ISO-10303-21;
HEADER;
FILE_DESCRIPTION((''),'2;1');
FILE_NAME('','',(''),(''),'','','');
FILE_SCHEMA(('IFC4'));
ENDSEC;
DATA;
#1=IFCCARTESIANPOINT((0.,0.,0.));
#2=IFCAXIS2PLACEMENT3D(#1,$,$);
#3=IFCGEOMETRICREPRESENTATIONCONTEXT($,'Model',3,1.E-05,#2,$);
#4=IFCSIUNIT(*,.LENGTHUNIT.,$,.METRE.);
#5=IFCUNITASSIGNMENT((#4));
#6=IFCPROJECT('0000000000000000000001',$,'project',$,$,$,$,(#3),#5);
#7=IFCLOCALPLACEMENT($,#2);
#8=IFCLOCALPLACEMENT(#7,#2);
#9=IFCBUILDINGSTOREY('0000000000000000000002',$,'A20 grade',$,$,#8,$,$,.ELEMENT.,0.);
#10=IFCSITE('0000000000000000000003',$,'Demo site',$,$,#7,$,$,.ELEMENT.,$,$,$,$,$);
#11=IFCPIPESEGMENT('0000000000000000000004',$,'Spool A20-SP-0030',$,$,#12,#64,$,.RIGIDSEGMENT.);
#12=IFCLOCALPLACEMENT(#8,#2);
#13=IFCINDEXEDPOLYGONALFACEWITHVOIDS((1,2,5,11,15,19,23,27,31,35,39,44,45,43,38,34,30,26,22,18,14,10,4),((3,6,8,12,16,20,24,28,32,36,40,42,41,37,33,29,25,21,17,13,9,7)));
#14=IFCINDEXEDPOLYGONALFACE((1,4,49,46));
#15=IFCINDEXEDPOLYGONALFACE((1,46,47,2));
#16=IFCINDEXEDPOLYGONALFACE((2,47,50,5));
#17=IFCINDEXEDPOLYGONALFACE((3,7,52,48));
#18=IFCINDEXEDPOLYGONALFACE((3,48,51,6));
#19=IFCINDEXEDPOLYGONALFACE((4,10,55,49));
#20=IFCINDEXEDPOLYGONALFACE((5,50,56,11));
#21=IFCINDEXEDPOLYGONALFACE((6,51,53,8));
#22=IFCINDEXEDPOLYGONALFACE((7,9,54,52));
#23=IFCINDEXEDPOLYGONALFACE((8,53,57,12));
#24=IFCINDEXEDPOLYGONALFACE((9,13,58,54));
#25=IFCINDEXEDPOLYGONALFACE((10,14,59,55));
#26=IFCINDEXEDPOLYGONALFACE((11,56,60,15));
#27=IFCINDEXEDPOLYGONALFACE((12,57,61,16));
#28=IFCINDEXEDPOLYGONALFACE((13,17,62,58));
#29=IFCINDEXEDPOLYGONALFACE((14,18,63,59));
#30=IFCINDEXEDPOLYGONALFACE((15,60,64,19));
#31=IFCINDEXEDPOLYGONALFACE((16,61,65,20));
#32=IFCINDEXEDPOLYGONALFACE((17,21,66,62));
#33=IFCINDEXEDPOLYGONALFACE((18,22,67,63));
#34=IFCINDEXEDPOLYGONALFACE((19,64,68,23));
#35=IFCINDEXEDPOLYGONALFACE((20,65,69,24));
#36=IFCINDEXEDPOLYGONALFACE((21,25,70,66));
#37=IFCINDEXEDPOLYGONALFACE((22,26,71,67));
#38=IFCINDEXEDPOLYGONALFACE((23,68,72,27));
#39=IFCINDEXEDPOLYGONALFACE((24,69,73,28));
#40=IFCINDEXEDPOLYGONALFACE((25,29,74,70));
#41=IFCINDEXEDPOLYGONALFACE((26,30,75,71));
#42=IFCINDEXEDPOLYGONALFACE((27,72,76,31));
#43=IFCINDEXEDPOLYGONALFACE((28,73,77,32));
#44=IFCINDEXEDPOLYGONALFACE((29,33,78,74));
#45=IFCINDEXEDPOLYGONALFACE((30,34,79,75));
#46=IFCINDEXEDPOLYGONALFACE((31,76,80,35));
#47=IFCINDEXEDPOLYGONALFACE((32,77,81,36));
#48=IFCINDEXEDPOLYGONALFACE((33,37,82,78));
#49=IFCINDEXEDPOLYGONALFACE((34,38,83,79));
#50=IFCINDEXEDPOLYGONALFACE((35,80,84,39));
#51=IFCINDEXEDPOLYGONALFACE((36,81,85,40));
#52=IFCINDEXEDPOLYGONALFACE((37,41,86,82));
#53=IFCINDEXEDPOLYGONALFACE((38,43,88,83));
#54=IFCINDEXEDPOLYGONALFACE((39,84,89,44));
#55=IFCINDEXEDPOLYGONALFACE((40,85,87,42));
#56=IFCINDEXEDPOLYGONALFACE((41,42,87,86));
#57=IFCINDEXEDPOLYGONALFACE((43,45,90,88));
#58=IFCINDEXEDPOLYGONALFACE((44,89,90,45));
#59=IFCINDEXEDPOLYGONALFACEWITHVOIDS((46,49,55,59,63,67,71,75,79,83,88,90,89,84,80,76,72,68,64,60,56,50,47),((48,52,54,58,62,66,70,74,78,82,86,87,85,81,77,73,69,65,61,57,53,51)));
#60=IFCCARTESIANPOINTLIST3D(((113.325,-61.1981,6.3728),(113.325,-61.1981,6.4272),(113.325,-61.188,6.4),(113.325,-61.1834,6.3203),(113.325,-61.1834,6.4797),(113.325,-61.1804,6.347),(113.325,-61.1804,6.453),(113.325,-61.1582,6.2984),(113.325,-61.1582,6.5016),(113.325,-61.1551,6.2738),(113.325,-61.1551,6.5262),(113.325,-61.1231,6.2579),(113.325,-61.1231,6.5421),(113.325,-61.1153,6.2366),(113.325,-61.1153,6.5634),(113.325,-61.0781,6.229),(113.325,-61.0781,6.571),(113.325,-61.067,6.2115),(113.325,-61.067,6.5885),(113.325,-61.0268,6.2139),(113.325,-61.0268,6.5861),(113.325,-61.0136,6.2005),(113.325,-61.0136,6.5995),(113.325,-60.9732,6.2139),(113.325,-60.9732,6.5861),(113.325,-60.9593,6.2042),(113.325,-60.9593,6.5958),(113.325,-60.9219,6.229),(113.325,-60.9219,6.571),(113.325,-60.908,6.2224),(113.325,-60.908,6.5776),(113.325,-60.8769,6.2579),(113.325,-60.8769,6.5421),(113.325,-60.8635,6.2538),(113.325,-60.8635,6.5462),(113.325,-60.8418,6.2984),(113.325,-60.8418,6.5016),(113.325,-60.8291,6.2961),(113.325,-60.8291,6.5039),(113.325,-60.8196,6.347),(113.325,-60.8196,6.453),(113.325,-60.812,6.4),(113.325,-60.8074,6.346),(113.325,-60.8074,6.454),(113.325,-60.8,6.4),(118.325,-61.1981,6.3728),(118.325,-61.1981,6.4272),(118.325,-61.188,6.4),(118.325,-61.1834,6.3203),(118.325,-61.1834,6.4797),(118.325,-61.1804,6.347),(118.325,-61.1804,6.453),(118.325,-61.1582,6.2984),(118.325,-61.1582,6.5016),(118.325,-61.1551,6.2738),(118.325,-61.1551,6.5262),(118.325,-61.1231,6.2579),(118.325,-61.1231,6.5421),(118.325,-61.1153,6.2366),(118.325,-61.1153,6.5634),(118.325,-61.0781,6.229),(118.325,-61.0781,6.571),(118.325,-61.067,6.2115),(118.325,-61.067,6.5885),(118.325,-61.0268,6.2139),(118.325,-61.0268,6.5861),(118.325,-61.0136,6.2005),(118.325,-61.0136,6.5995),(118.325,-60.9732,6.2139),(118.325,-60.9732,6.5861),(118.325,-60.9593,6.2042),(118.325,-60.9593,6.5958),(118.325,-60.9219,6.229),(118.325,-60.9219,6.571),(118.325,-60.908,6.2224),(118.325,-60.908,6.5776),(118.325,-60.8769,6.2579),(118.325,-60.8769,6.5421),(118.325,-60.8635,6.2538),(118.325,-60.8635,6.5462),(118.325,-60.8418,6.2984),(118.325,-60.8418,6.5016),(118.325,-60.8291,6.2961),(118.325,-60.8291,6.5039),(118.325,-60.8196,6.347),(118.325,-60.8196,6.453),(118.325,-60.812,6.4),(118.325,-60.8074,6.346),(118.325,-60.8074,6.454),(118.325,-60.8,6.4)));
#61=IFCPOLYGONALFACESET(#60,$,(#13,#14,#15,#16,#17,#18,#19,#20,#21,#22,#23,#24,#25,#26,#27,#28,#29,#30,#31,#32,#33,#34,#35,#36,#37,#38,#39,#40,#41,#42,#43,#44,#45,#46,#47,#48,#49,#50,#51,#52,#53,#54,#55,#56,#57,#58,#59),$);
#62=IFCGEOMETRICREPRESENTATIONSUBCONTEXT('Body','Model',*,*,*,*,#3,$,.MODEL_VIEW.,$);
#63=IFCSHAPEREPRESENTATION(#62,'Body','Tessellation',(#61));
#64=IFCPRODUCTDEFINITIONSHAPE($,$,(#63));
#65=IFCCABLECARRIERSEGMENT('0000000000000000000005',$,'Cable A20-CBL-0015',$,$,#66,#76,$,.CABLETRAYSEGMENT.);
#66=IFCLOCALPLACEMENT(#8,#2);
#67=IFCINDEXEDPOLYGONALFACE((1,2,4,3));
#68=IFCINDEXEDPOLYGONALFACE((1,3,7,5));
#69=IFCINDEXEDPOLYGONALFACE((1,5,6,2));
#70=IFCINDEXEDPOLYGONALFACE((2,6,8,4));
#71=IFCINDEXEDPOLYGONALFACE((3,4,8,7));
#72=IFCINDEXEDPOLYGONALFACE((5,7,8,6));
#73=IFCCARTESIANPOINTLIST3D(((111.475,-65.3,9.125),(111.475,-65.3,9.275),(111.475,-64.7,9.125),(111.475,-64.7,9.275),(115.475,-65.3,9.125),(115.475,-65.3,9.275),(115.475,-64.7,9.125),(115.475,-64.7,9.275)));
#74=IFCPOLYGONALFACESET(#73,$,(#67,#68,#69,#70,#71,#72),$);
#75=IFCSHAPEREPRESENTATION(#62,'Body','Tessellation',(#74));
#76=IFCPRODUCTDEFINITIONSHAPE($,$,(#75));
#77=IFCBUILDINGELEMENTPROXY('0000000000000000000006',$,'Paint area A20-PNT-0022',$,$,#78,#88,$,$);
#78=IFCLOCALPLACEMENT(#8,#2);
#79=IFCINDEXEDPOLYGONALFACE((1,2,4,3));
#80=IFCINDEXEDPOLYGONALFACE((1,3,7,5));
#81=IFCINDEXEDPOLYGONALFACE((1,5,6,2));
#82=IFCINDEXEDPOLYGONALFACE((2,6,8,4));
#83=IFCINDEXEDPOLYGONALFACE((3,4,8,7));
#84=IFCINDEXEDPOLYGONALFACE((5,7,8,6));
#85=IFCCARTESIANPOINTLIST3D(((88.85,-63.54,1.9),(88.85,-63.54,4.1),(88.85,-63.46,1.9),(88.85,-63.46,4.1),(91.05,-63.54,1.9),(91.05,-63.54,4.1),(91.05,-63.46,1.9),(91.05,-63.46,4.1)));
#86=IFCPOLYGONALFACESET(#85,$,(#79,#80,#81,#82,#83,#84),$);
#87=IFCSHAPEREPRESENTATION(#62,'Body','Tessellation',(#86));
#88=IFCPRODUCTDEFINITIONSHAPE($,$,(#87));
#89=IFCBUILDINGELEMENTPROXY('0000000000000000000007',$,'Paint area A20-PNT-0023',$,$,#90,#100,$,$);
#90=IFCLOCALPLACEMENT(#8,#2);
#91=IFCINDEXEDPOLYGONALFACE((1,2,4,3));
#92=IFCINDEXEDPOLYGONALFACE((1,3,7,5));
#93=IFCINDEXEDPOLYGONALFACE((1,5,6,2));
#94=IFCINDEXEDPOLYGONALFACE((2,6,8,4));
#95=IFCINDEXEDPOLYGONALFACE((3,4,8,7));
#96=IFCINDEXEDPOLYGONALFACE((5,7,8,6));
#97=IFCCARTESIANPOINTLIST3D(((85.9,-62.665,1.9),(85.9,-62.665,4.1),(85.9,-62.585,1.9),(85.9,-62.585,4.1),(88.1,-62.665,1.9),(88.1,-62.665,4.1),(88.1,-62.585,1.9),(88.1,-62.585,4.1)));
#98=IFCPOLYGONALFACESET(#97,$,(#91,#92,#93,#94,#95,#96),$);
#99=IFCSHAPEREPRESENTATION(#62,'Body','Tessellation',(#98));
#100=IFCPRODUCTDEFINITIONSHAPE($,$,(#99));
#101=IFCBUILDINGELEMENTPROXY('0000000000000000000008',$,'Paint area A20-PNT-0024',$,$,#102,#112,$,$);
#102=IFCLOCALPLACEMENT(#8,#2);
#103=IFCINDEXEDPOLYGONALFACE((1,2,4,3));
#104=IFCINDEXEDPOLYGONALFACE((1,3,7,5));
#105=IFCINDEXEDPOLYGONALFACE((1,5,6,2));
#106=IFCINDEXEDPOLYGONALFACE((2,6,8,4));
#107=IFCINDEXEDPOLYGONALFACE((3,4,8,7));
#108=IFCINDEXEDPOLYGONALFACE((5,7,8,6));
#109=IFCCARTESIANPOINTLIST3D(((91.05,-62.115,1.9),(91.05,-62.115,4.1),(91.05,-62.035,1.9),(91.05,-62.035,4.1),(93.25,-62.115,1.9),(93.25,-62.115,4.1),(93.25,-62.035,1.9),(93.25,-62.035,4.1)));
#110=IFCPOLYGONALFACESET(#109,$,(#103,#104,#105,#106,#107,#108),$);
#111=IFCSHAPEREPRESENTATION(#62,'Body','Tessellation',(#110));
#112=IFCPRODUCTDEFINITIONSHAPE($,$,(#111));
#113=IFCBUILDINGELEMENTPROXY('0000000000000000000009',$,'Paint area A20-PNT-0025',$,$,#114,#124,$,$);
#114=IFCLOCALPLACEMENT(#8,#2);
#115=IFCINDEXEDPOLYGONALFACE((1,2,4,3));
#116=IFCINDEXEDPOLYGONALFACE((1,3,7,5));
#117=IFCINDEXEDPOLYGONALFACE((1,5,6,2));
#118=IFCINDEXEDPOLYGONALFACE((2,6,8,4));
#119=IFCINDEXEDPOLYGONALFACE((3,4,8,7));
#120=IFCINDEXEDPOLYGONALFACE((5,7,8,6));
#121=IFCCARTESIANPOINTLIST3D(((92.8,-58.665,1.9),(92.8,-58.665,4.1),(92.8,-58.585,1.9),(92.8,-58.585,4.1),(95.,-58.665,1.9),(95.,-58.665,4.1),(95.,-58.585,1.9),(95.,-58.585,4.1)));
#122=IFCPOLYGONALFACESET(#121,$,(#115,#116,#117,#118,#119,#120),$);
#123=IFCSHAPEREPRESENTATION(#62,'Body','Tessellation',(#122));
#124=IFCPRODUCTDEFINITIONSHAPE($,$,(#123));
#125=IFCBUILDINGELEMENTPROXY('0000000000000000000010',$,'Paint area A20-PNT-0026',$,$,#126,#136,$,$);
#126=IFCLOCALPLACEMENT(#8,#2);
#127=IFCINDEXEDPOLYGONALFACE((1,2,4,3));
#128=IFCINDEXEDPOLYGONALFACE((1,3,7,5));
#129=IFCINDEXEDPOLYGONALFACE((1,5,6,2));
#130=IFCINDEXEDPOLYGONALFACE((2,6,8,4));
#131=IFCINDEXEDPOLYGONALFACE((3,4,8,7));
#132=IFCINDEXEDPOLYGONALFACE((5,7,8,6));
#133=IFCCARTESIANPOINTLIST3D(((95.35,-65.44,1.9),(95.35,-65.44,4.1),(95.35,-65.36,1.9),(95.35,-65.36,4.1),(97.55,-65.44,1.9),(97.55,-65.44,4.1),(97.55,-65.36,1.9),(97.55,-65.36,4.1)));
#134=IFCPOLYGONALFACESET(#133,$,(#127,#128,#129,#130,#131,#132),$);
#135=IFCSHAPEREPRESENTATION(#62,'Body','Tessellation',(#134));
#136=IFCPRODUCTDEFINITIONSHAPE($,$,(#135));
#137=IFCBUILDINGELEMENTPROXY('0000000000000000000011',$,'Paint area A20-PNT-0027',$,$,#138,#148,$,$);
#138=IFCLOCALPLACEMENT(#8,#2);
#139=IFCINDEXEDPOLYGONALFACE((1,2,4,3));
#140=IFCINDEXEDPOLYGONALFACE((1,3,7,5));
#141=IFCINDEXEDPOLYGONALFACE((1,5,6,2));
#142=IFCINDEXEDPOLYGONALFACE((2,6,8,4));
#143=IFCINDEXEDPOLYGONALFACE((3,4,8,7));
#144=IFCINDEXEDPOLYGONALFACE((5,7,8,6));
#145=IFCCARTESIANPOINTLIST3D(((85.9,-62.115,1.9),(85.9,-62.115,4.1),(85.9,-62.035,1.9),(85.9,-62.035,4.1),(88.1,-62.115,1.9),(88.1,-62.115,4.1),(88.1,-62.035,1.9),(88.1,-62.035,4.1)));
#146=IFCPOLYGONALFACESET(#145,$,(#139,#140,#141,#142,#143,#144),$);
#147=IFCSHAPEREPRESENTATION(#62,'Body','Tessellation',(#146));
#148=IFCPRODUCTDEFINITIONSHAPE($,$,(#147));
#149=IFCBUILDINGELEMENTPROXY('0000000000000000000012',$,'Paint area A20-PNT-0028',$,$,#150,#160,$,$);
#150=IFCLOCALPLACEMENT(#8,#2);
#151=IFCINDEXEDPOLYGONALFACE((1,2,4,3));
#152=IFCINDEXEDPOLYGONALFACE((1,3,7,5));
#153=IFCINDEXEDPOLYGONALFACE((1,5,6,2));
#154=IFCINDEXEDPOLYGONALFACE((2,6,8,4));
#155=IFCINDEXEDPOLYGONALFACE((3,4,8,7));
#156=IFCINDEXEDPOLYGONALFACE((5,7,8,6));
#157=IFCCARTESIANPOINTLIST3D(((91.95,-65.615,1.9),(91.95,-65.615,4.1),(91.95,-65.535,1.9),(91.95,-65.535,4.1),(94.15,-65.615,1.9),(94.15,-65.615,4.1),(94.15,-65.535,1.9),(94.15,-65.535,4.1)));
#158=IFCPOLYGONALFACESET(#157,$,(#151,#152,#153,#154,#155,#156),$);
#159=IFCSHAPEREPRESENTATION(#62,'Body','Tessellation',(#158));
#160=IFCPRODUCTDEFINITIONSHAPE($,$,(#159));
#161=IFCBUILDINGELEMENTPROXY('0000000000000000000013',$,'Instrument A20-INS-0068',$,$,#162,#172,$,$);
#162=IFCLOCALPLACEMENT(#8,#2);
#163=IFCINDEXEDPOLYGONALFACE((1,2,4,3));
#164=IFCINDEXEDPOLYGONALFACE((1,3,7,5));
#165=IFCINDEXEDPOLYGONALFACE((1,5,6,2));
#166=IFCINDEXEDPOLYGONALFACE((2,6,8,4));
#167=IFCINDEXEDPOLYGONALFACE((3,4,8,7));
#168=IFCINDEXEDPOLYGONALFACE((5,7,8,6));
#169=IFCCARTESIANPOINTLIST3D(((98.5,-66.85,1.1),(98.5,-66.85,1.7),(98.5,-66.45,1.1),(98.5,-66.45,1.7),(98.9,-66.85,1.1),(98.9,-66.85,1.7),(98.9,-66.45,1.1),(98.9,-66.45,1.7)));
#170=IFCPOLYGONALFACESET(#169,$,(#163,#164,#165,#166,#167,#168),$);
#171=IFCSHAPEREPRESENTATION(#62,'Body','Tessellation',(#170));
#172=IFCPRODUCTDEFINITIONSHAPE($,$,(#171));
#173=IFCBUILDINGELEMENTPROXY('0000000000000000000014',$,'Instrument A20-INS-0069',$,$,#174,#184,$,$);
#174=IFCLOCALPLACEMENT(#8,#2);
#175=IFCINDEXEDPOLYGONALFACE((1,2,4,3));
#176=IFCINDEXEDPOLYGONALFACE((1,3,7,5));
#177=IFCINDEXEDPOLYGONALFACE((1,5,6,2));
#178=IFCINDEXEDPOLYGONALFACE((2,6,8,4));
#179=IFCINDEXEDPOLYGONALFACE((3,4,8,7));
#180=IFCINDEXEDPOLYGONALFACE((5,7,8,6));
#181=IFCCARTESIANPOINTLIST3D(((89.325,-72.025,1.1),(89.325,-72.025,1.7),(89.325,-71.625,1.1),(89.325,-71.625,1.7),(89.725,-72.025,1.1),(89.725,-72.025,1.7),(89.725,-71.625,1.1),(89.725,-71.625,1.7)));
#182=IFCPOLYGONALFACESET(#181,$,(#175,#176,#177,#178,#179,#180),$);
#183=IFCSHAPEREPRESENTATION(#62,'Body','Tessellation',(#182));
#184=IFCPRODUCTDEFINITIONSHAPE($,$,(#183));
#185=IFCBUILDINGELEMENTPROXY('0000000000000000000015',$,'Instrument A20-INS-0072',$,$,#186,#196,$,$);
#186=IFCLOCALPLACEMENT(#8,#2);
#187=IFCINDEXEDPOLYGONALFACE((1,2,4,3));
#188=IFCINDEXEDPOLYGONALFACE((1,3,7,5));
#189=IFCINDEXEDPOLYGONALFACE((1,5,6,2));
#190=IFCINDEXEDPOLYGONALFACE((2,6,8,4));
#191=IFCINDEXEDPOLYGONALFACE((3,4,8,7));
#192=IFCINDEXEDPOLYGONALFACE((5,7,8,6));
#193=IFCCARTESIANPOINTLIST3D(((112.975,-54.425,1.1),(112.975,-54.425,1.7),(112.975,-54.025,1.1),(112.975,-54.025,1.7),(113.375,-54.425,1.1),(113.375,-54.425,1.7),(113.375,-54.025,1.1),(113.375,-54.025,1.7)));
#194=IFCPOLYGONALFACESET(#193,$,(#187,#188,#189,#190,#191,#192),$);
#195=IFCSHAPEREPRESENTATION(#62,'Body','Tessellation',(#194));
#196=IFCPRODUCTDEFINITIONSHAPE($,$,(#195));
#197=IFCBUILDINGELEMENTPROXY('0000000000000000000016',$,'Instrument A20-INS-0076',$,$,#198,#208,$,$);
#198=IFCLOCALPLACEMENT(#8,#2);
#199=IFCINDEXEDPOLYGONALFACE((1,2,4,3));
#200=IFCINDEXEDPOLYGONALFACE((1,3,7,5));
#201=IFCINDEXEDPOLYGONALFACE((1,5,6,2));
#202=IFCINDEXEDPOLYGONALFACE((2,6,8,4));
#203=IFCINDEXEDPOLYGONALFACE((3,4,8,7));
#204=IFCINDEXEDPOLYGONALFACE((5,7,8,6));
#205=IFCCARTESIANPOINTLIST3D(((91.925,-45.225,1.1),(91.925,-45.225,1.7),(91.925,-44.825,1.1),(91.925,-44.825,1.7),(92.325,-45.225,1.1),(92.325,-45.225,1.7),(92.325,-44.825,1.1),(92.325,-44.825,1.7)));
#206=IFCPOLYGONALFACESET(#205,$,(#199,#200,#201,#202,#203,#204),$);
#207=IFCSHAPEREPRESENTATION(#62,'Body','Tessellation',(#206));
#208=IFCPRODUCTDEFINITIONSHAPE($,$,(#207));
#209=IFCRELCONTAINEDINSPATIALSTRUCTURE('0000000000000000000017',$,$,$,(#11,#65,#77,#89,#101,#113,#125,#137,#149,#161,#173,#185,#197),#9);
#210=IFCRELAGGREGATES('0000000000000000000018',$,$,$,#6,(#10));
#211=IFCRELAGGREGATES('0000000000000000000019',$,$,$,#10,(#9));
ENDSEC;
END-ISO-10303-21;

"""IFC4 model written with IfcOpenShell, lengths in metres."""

from ifc_helpers import new_model, si_unit, frame, origin, place, context, subcontext, project, spatial, rectangle, hollow_circle, extrude, element, save


model = new_model("IFC4")

# Units and contexts
model_context = context("Model", 3, precision=1e-05, world=origin())
body_context = subcontext(model_context, "Body", "Model", "MODEL_VIEW")
ifc_project = project(units=[si_unit("LENGTHUNIT", "METRE")], contexts=[model_context])

# Site, storey
site_placement = place(None, origin())
site = spatial("IfcSite", under=ifc_project, at=site_placement, Name="Demo site", CompositionType="ELEMENT")
storey_placement = place(site_placement, origin())
storey = spatial("IfcBuildingStorey", under=site, at=storey_placement, Name="A20 grade", CompositionType="ELEMENT", Elevation=0.0)

# Pipe segment
for number, where, name in (
    (1, (113.325, -61.0, 6.4), "Spool A20-SP-0030"),
):
    element("IfcPipeSegment", number, at=place(storey_placement, frame(where)), inside=storey, Name=name, PredefinedType="RIGIDSEGMENT", context=body_context, shape_type="SweptSolid", body=[
        extrude(hollow_circle(Radius=0.2, WallThickness=0.012), frame((0.0, 0.0, 0.0), z_axis=(1.0, 0.0, 0.0), x_axis=(0.0, 1.0, 0.0)), (0.0, 0.0, 1.0), 5.0),
    ])

# Cable carrier segment
cable_carrier_segment_placement = place(storey_placement, frame((111.475, -65.0, 9.2)))
element("IfcCableCarrierSegment", 2, at=cable_carrier_segment_placement, inside=storey, Name="Cable A20-CBL-0015", PredefinedType="CABLETRAYSEGMENT", context=body_context, shape_type="SweptSolid", body=[
    extrude(rectangle(XDim=0.6, YDim=0.15), frame((0.0, 0.0, 0.0), z_axis=(1.0, 0.0, 0.0), x_axis=(0.0, 1.0, 0.0)), (0.0, 0.0, 1.0), 4.0),
])

# Building element proxies
for number, where, name in (
    (3, (89.95, -63.5, 1.9), "Paint area A20-PNT-0022"),
    (4, (87.0, -62.625, 1.9), "Paint area A20-PNT-0023"),
    (5, (92.15, -62.075, 1.9), "Paint area A20-PNT-0024"),
    (6, (93.9, -58.625, 1.9), "Paint area A20-PNT-0025"),
    (7, (96.45, -65.4, 1.9), "Paint area A20-PNT-0026"),
    (8, (87.0, -62.075, 1.9), "Paint area A20-PNT-0027"),
    (9, (93.05, -65.575, 1.9), "Paint area A20-PNT-0028"),
):
    element("IfcBuildingElementProxy", number, at=place(storey_placement, frame(where)), inside=storey, Name=name, context=body_context, shape_type="SweptSolid", body=[
        extrude(rectangle(XDim=2.2, YDim=0.08), origin(), (0.0, 0.0, 1.0), 2.2),
    ])
for number, where, name in (
    (10, (98.7, -66.65, 1.1), "Instrument A20-INS-0068"),
    (11, (89.525, -71.825, 1.1), "Instrument A20-INS-0069"),
    (12, (113.175, -54.225, 1.1), "Instrument A20-INS-0072"),
    (13, (92.125, -45.025, 1.1), "Instrument A20-INS-0076"),
):
    element("IfcBuildingElementProxy", number, at=place(storey_placement, frame(where)), inside=storey, Name=name, context=body_context, shape_type="SweptSolid", body=[
        extrude(rectangle(XDim=0.4, YDim=0.4), origin(), (0.0, 0.0, 1.0), 0.6),
    ])

save(model, "model.ifc")
